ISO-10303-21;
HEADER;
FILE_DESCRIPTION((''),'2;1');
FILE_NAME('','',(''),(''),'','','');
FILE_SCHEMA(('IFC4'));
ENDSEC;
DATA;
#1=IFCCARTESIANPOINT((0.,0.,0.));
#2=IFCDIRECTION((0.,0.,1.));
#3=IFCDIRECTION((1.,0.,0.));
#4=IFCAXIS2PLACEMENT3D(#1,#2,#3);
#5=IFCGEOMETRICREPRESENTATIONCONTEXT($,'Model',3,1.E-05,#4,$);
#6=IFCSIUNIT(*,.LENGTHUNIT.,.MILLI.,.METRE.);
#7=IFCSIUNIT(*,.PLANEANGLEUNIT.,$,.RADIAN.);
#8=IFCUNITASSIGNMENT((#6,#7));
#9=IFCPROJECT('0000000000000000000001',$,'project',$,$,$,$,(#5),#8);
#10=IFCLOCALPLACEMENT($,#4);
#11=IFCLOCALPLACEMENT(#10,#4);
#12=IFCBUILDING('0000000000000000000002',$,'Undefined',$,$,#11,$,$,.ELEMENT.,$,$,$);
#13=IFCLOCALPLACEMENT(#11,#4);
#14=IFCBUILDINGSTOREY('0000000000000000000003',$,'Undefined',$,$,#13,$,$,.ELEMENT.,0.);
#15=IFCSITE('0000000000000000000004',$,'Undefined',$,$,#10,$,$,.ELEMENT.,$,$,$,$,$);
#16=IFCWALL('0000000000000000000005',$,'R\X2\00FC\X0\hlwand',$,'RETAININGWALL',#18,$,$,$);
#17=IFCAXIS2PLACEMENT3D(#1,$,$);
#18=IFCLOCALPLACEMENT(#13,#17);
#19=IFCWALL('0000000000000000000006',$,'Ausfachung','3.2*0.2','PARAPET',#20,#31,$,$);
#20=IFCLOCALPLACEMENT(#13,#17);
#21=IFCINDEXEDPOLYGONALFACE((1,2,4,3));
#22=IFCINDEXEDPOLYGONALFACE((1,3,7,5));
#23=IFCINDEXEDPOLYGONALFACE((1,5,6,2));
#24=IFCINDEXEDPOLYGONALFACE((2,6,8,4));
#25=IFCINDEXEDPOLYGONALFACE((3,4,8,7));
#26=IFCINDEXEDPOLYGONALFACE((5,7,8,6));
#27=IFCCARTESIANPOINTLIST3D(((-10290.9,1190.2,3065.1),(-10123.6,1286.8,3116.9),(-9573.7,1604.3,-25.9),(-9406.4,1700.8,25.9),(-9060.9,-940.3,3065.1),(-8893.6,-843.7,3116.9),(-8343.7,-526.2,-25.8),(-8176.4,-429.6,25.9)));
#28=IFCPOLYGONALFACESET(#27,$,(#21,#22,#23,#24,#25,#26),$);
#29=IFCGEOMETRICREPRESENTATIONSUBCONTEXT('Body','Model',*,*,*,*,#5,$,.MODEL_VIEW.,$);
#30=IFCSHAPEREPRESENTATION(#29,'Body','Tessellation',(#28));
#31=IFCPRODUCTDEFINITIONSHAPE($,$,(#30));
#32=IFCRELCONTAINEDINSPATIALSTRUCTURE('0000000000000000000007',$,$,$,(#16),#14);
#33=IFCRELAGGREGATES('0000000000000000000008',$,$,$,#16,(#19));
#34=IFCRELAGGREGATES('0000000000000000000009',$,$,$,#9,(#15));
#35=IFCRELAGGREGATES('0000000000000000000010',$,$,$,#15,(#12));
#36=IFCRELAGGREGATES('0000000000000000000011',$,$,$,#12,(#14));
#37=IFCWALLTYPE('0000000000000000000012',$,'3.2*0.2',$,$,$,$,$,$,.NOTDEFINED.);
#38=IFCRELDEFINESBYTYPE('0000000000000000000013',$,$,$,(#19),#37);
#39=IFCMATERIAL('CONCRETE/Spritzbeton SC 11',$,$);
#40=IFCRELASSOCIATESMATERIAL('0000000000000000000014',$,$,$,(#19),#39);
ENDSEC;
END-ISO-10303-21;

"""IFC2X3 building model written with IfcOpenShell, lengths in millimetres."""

from ifc_helpers import new_model, si_unit, frame, frame_2d, origin_with_axes, place, context, subcontext, project, spatial, rectangle, extrude, material, type_object, element, aggregate, save


model = new_model("IFC2X3")

# Units and contexts
model_context = context("Model", 3, precision=1e-05, world=origin_with_axes())
body_context = subcontext(model_context, "Body", "Model", "MODEL_VIEW")
ifc_project = project(units=[si_unit("LENGTHUNIT", "METRE", prefix="MILLI"), si_unit("PLANEANGLEUNIT", "RADIAN")], contexts=[model_context])

# Site, building, storey
site_placement = place(None, origin_with_axes())
site = spatial("IfcSite", under=ifc_project, at=site_placement, Name="Undefined", CompositionType="ELEMENT")
building_placement = place(site_placement, origin_with_axes())
building = spatial("IfcBuilding", under=site, at=building_placement, Name="Undefined", CompositionType="ELEMENT")
storey_placement = place(building_placement, origin_with_axes())
storey = spatial("IfcBuildingStorey", under=building, at=storey_placement, Name="Undefined", CompositionType="ELEMENT", Elevation=0.0)

# Wall
wall_1_placement = place(storey_placement, origin_with_axes())
wall_1 = element("IfcWall", 1, at=wall_1_placement, inside=storey, Name="Rühlwand", ObjectType="RETAININGWALL")

# Wall
ifc_material_1 = material(Name="CONCRETE/Spritzbeton SC 11")
wall_type = type_object("IfcWallType", Name="3.2*0.2", PredefinedType="NOTDEFINED")
wall_2_placement = place(wall_1_placement, frame((-9490.0, 1652.6, 0.0), z_axis=(-0.224147, -0.129405, 0.965926), x_axis=(0.499999, -0.866026, 0.000005)))
wall_2 = element("IfcWall", 2, at=wall_2_placement, type_object=wall_type, material=ifc_material_1, Name="Ausfachung", Description="3.2*0.2", ObjectType="PARAPET", context=body_context, shape_type="SweptSolid", body=[
    extrude(rectangle(XDim=2460.0, YDim=200.0, at=frame_2d((0.0, 1230.0), x_axis=(0.0, -1.0))), frame((0.0, 0.0, 0.0), z_axis=(0.0, 0.0, 1.0), x_axis=(0.0, -1.0, 0.0)), (0.0, 0.0, 1.0), 3200.0),
])

aggregate(wall_1, [wall_2])

save(model, "model.ifc")
